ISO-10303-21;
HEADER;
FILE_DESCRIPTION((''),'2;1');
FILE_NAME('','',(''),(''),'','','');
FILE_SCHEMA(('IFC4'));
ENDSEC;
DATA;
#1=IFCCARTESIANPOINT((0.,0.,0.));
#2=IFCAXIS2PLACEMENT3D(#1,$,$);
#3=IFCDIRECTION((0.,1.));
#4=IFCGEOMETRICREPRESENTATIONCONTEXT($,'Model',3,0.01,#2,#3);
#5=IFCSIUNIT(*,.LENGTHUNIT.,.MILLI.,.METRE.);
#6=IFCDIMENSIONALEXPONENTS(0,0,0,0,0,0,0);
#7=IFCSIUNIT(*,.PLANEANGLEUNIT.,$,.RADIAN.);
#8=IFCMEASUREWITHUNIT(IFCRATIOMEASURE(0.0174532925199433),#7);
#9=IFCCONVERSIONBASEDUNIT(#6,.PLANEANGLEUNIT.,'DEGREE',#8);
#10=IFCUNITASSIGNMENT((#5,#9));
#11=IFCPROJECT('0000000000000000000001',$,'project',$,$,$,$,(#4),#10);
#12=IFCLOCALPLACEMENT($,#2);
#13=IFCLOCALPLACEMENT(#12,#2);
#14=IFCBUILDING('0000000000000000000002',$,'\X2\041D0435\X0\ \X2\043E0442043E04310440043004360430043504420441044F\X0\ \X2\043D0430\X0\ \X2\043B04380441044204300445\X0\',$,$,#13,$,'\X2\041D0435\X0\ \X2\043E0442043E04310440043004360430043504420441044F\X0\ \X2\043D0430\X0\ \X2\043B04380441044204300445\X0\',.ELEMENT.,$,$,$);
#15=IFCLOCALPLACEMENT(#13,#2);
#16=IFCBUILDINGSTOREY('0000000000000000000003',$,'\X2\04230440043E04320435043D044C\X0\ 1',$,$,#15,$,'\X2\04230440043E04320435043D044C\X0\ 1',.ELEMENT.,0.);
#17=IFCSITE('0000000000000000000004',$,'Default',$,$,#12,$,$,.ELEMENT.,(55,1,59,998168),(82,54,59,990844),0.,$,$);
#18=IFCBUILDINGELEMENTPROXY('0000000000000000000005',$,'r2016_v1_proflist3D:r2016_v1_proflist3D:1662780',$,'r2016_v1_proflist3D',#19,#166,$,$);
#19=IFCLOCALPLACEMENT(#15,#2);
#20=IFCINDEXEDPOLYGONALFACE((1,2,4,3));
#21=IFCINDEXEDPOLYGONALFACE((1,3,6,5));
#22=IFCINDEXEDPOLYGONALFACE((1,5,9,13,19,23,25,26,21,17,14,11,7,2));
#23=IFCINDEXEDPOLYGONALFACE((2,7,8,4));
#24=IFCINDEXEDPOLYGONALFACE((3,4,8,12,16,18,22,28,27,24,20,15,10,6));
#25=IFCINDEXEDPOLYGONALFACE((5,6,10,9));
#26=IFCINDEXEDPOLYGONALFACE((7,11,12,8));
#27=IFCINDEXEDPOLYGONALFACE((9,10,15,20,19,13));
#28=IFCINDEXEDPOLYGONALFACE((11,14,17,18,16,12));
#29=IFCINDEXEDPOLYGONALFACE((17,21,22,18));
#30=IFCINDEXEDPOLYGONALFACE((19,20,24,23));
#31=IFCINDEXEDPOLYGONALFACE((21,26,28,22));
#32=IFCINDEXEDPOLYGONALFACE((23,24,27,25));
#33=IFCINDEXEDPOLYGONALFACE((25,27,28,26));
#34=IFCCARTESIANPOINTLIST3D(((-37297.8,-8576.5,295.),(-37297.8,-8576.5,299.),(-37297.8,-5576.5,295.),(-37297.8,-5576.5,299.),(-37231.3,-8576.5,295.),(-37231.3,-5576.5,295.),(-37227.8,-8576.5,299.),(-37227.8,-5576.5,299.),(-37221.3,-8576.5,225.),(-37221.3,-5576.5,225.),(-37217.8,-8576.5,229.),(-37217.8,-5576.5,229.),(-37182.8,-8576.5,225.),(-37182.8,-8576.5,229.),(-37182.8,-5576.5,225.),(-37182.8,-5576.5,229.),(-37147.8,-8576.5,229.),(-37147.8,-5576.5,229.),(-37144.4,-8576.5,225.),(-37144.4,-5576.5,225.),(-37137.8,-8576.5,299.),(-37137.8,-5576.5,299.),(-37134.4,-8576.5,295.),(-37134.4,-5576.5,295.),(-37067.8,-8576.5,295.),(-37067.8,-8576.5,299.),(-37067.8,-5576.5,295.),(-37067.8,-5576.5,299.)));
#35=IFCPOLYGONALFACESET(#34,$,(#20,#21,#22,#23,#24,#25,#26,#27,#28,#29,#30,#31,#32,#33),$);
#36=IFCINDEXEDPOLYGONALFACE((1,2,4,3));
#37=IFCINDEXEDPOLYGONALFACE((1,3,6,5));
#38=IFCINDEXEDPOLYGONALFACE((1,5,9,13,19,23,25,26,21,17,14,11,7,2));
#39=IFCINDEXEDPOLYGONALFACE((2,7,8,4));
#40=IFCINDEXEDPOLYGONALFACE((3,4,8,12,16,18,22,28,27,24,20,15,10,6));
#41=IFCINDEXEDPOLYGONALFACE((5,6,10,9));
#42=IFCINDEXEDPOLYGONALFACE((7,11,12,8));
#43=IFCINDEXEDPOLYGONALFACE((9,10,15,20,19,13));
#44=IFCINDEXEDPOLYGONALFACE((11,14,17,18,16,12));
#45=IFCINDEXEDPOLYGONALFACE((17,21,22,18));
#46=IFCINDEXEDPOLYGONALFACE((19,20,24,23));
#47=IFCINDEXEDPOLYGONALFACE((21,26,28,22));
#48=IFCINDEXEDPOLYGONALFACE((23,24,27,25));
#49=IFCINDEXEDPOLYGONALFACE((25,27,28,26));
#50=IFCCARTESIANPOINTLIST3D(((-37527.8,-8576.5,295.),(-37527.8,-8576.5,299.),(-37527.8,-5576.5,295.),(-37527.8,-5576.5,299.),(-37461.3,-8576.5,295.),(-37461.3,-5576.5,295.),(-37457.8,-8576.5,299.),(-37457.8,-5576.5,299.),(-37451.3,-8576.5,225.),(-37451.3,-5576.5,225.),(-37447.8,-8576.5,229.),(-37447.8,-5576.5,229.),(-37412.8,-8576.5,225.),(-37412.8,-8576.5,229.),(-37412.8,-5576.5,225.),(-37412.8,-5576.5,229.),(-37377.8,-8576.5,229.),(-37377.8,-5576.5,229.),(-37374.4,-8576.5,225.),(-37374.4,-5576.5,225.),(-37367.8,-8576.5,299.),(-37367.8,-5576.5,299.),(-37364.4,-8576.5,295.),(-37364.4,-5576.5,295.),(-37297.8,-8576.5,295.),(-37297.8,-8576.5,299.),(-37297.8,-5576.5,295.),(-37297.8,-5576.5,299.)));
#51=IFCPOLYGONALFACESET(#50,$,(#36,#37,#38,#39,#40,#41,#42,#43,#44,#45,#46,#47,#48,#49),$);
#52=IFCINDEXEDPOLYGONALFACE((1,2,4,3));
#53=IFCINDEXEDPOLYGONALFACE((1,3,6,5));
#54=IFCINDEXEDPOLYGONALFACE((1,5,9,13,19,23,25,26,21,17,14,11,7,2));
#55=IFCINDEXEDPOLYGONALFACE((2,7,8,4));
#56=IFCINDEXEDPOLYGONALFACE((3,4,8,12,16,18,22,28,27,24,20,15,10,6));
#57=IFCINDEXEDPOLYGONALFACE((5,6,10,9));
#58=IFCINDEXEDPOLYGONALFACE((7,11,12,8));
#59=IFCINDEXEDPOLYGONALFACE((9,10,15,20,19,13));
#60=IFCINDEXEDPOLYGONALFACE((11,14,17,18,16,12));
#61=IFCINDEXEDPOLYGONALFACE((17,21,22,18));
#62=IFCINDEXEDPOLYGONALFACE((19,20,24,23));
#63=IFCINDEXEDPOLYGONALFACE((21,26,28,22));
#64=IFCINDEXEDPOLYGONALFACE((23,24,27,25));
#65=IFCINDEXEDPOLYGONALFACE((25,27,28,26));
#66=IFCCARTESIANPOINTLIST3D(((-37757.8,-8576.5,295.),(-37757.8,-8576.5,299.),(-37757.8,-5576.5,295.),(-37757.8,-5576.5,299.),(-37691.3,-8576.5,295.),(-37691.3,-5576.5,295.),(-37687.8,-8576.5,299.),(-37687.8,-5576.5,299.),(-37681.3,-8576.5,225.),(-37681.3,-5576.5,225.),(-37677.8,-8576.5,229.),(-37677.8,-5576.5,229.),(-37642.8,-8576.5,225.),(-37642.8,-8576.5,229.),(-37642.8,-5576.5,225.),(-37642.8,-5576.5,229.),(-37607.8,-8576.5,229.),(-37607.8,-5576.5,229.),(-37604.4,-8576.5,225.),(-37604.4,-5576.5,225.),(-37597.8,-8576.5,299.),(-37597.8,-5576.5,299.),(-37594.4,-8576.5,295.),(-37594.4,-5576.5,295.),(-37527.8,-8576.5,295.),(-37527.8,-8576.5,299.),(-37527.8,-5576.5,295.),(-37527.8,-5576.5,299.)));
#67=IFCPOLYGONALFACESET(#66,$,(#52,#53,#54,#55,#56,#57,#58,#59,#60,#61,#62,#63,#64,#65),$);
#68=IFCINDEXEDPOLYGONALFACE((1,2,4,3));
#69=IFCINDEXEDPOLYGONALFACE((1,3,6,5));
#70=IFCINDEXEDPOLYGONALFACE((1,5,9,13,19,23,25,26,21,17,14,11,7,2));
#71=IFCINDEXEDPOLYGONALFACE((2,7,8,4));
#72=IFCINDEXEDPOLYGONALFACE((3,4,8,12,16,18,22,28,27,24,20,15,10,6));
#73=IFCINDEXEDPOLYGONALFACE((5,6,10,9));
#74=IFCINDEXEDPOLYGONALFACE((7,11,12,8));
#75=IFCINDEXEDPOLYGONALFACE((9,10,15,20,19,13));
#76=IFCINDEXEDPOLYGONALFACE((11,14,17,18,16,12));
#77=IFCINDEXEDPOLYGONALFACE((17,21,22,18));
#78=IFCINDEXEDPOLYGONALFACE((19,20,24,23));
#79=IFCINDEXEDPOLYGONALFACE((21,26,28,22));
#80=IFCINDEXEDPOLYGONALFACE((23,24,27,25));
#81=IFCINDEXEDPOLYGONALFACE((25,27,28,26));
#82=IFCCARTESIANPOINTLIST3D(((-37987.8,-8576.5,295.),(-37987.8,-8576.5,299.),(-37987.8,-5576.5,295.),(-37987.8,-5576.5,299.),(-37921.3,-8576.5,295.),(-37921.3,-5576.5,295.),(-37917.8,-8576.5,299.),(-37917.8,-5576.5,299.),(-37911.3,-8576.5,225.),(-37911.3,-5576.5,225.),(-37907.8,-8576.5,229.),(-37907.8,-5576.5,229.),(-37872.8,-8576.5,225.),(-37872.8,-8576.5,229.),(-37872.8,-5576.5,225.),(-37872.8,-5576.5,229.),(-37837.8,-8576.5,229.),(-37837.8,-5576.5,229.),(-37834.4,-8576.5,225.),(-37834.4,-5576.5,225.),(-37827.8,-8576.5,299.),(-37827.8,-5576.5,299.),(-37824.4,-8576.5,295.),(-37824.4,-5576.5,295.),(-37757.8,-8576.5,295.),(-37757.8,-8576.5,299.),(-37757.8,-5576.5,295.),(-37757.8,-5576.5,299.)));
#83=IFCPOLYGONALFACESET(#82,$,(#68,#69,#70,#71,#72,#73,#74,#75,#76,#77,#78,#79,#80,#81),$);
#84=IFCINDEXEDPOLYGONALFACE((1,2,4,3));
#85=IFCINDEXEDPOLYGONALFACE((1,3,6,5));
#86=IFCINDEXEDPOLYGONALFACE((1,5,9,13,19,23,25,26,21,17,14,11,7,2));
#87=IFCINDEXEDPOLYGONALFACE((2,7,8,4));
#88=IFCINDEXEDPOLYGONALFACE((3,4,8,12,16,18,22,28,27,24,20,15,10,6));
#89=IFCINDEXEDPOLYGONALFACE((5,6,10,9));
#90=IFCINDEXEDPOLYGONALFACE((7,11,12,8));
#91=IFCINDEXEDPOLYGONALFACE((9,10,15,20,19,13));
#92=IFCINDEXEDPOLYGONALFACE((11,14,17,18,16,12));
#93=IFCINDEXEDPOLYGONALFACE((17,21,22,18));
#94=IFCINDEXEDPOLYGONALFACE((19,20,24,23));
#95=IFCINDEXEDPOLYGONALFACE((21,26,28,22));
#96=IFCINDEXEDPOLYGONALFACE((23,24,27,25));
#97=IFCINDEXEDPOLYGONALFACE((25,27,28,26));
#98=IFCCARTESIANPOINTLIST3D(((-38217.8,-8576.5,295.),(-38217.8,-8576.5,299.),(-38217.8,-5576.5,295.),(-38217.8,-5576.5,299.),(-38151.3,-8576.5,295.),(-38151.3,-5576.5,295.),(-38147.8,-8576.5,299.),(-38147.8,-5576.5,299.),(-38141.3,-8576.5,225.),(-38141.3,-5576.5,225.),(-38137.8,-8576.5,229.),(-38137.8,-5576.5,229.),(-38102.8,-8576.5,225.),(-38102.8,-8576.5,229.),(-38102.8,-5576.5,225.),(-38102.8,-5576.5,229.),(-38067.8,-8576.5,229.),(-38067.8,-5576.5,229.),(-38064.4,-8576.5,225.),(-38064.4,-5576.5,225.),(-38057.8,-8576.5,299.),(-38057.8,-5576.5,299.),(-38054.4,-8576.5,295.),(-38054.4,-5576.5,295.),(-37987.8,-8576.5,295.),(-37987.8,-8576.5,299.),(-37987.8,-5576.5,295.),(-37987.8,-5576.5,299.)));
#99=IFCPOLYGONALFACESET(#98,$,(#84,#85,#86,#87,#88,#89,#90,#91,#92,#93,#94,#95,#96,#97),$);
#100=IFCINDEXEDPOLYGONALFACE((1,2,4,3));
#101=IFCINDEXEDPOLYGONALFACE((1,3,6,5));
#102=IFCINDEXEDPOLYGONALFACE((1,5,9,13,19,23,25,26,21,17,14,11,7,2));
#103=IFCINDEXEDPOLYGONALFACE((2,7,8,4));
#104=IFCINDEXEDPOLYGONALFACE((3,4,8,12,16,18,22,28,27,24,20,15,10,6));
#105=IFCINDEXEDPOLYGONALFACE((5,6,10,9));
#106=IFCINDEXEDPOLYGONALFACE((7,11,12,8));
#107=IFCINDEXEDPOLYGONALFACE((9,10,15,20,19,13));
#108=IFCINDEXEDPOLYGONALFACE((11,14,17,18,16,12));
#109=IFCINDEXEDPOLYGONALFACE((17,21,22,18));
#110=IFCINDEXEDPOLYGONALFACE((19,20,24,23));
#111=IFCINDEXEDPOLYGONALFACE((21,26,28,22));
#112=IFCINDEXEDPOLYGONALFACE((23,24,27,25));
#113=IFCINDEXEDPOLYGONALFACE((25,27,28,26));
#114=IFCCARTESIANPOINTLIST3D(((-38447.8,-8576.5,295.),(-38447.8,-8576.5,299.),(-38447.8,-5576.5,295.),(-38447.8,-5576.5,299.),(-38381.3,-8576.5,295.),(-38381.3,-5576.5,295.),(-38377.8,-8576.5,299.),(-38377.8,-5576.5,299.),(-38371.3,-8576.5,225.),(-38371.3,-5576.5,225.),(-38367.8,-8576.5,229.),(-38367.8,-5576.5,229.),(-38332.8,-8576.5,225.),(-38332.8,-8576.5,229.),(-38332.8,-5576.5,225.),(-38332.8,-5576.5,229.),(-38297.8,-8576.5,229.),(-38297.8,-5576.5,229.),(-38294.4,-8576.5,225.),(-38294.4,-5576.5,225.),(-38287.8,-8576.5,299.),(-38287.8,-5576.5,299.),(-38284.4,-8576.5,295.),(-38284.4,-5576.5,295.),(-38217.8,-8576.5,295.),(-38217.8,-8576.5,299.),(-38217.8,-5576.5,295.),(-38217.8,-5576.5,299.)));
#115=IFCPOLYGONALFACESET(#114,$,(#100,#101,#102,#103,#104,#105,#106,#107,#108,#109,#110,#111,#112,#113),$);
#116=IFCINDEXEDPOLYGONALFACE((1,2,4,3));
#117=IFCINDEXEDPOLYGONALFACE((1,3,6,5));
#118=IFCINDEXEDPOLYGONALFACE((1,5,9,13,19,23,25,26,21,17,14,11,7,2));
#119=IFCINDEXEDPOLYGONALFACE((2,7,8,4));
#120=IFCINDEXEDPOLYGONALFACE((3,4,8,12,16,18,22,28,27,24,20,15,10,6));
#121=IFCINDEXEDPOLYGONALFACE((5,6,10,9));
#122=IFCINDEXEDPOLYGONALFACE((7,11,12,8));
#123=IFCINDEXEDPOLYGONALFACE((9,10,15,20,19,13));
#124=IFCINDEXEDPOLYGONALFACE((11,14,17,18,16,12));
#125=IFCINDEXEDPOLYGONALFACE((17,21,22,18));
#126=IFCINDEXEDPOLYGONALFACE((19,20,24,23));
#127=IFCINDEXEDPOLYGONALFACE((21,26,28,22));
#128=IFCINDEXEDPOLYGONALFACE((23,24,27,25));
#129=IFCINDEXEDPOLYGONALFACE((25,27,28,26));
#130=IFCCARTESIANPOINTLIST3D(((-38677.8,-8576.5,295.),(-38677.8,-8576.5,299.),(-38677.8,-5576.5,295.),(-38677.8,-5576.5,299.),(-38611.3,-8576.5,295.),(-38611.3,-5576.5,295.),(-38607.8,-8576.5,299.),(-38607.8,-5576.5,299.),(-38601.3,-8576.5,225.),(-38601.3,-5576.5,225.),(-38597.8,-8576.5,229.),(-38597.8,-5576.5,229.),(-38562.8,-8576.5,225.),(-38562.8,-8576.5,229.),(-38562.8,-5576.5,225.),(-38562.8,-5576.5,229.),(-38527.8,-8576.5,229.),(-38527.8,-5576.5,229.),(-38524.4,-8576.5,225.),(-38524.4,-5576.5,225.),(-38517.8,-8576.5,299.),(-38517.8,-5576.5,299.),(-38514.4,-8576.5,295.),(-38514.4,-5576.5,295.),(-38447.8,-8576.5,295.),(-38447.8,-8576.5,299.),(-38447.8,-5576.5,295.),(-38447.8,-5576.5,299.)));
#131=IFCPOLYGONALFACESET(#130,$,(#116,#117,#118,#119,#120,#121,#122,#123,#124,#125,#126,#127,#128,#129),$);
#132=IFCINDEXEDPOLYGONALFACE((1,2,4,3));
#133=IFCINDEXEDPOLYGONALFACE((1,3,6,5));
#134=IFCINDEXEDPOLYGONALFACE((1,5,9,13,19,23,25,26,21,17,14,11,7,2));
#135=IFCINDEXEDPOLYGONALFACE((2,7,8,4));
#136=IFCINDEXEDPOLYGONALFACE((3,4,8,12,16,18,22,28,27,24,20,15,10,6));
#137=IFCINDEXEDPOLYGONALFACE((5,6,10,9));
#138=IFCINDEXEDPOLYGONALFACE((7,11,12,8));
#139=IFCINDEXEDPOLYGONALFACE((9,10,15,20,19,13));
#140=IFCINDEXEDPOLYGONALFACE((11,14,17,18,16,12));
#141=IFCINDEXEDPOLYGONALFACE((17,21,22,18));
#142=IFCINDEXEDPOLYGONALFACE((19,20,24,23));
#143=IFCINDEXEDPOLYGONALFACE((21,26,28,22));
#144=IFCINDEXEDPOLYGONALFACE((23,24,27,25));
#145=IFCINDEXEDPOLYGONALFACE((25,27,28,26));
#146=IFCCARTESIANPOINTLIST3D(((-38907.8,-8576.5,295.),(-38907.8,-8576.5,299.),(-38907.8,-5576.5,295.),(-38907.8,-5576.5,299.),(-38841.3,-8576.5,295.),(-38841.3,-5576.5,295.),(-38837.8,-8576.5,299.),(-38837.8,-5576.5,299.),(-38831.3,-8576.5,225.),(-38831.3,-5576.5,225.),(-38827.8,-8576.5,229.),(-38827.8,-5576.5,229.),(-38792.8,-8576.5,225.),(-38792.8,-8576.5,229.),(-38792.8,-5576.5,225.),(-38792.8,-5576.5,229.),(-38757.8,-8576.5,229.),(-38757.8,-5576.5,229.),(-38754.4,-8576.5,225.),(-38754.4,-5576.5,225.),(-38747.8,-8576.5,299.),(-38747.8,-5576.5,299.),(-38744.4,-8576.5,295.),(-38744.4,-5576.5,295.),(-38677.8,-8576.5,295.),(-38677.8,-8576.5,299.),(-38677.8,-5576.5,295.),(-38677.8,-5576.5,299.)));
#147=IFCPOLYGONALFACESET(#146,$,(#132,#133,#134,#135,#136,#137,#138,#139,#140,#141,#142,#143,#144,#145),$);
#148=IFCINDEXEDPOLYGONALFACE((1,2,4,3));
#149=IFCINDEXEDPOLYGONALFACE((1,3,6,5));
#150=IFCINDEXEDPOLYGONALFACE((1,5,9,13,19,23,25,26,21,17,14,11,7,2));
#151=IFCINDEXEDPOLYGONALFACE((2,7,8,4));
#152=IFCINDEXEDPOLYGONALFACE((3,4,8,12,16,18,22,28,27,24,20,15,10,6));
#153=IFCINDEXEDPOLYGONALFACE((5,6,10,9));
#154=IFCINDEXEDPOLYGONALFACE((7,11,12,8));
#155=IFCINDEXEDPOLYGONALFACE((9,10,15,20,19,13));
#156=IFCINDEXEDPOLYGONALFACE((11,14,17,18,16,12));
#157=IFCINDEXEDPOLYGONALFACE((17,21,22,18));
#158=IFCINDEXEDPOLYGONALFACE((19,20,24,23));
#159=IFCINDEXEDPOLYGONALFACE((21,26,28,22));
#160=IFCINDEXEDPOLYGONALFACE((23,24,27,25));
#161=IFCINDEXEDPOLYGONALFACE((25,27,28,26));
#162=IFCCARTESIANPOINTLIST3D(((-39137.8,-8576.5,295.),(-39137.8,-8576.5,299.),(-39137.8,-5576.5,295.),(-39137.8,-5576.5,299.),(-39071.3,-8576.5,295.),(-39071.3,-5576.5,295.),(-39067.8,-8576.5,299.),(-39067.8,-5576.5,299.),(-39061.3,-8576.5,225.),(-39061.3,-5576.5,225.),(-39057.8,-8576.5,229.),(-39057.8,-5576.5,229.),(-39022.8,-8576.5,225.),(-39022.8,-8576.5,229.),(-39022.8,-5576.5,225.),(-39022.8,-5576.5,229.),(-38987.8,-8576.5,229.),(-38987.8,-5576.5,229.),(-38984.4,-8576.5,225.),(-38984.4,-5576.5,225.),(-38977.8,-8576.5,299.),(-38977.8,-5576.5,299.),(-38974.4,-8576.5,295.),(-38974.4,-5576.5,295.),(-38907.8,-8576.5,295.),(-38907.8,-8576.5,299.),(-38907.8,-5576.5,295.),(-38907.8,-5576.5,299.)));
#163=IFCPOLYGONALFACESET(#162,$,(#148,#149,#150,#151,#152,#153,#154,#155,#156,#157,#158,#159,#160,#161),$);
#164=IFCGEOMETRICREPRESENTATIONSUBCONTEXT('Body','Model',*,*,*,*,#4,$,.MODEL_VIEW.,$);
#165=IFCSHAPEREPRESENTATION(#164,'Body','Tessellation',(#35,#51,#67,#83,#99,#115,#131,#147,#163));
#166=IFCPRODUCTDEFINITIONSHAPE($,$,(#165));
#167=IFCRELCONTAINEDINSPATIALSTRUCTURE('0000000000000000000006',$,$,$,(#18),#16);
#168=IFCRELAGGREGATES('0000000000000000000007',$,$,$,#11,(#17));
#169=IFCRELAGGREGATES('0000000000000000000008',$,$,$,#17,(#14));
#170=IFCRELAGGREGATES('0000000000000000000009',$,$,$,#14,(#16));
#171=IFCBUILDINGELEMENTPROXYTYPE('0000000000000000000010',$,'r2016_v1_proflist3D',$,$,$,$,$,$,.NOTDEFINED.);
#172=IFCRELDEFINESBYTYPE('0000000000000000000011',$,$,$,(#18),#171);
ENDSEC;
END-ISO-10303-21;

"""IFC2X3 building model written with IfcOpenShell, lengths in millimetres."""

from ifc_helpers import new_model, entity, si_unit, converted_unit, direction, frame, origin, place, context, subcontext, project, spatial, polyline, outline, extrude, source, transform, mapped, type_object, type_shapes, element, save


model = new_model("IFC2X3")

# Units and contexts
model_context = context("Model", 3, precision=0.01, world=origin(), true_north=direction((0.0, 1.0)))
body_context = subcontext(model_context, "Body", "Model", "MODEL_VIEW")
ifc_project = project(units=[si_unit("LENGTHUNIT", "METRE", prefix="MILLI"), converted_unit("PLANEANGLEUNIT", "DEGREE", entity("IfcRatioMeasure", 0.0174532925199433), si_unit("PLANEANGLEUNIT", "RADIAN"), dimensions=[0, 0, 0, 0, 0, 0, 0])], contexts=[model_context])

# Site, building, storey
site_placement = place(None, origin())
site = spatial("IfcSite", under=ifc_project, at=site_placement, Name="Default", CompositionType="ELEMENT", RefLatitude=(55, 1, 59, 998168), RefLongitude=(82, 54, 59, 990844), RefElevation=0.0)
building_placement = place(site_placement, origin())
building = spatial("IfcBuilding", under=site, at=building_placement, Name="Не отображается на листах", LongName="Не отображается на листах", CompositionType="ELEMENT")
storey_placement = place(building_placement, frame((0.0, 0.0, 0.0)))
storey = spatial("IfcBuildingStorey", under=building, at=storey_placement, Name="Уровень 1", LongName="Уровень 1", CompositionType="ELEMENT", Elevation=0.0)

# Building element proxy
building_element_proxy_type = type_object("IfcBuildingElementProxyType", Name="r2016_v1_proflist3D", PredefinedType="NOTDEFINED")
shared_shape = source(origin(), body_context, "Body", "SweptSolid", [
    extrude(outline(polyline([(-38.0, -40.0), (-47.9, -109.3), (-44.0, -109.9), (-34.6, -44.0), (36.1, -44.0), (41.6, -5.9), (47.0, 32.1), (-20.9, 51.9), (-11.5, 117.8), (-15.4, 118.4), (-25.3, 49.1), (42.6, 29.3), (37.6, -5.4), (32.7, -40.0), (-38.0, -40.0)])), frame((1955.0, -3000.0, -32.0), z_axis=(0.0, -1.0, 0.0), x_axis=(0.141421, 0.0, -0.989949)), (0.0, 0.0, -1.0), 3000.0),
    extrude(outline(polyline([(-38.0, -40.0), (-47.9, -109.3), (-44.0, -109.9), (-34.6, -44.0), (36.1, -44.0), (41.6, -5.9), (47.0, 32.1), (-20.9, 51.9), (-11.5, 117.8), (-15.4, 118.4), (-25.3, 49.1), (42.6, 29.3), (37.6, -5.4), (32.7, -40.0), (-38.0, -40.0)])), frame((1725.0, -3000.0, -32.0), z_axis=(0.0, -1.0, 0.0), x_axis=(0.141421, 0.0, -0.989949)), (0.0, 0.0, -1.0), 3000.0),
    extrude(outline(polyline([(-38.0, -40.0), (-47.9, -109.3), (-44.0, -109.9), (-34.6, -44.0), (36.1, -44.0), (41.6, -5.9), (47.0, 32.1), (-20.9, 51.9), (-11.5, 117.8), (-15.4, 118.4), (-25.3, 49.1), (42.6, 29.3), (37.6, -5.4), (32.7, -40.0), (-38.0, -40.0)])), frame((1495.0, -3000.0, -32.0), z_axis=(0.0, -1.0, 0.0), x_axis=(0.141421, 0.0, -0.989949)), (0.0, 0.0, -1.0), 3000.0),
    extrude(outline(polyline([(-38.0, -40.0), (-47.9, -109.3), (-44.0, -109.9), (-34.6, -44.0), (36.1, -44.0), (41.6, -5.9), (47.0, 32.1), (-20.9, 51.9), (-11.5, 117.8), (-15.4, 118.4), (-25.3, 49.1), (42.6, 29.3), (37.6, -5.4), (32.7, -40.0), (-38.0, -40.0)])), frame((1265.0, -3000.0, -32.0), z_axis=(0.0, -1.0, 0.0), x_axis=(0.141421, 0.0, -0.989949)), (0.0, 0.0, -1.0), 3000.0),
    extrude(outline(polyline([(-38.0, -40.0), (-47.9, -109.3), (-44.0, -109.9), (-34.6, -44.0), (36.1, -44.0), (41.6, -5.9), (47.0, 32.1), (-20.9, 51.9), (-11.5, 117.8), (-15.4, 118.4), (-25.3, 49.1), (42.6, 29.3), (37.6, -5.4), (32.7, -40.0), (-38.0, -40.0)])), frame((1035.0, -3000.0, -32.0), z_axis=(0.0, -1.0, 0.0), x_axis=(0.141421, 0.0, -0.989949)), (0.0, 0.0, -1.0), 3000.0),
    extrude(outline(polyline([(-38.0, -40.0), (-47.9, -109.3), (-44.0, -109.9), (-34.6, -44.0), (36.1, -44.0), (41.6, -5.9), (47.0, 32.1), (-20.9, 51.9), (-11.5, 117.8), (-15.4, 118.4), (-25.3, 49.1), (42.6, 29.3), (37.6, -5.4), (32.7, -40.0), (-38.0, -40.0)])), frame((805.0, -3000.0, -32.0), z_axis=(0.0, -1.0, 0.0), x_axis=(0.141421, 0.0, -0.989949)), (0.0, 0.0, -1.0), 3000.0),
    extrude(outline(polyline([(-38.0, -40.0), (-47.9, -109.3), (-44.0, -109.9), (-34.6, -44.0), (36.1, -44.0), (41.6, -5.9), (47.0, 32.1), (-20.9, 51.9), (-11.5, 117.8), (-15.4, 118.4), (-25.3, 49.1), (42.6, 29.3), (37.6, -5.4), (32.7, -40.0), (-38.0, -40.0)])), frame((575.0, -3000.0, -32.0), z_axis=(0.0, -1.0, 0.0), x_axis=(0.141421, 0.0, -0.989949)), (0.0, 0.0, -1.0), 3000.0),
    extrude(outline(polyline([(-38.0, -40.0), (-47.9, -109.3), (-44.0, -109.9), (-34.6, -44.0), (36.1, -44.0), (41.6, -5.9), (47.0, 32.1), (-20.9, 51.9), (-11.5, 117.8), (-15.4, 118.4), (-25.3, 49.1), (42.6, 29.3), (37.6, -5.4), (32.7, -40.0), (-38.0, -40.0)])), frame((345.0, -3000.0, -32.0), z_axis=(0.0, -1.0, 0.0), x_axis=(0.141421, 0.0, -0.989949)), (0.0, 0.0, -1.0), 3000.0),
    extrude(outline(polyline([(-38.0, -40.0), (-47.9, -109.3), (-44.0, -109.9), (-34.6, -44.0), (36.1, -44.0), (41.6, -5.9), (47.0, 32.1), (-20.9, 51.9), (-11.5, 117.8), (-15.4, 118.4), (-25.3, 49.1), (42.6, 29.3), (37.6, -5.4), (32.7, -40.0), (-38.0, -40.0)])), frame((115.0, -3000.0, -32.0), z_axis=(0.0, -1.0, 0.0), x_axis=(0.141421, 0.0, -0.989949)), (0.0, 0.0, -1.0), 3000.0),
])
type_shapes(building_element_proxy_type, [shared_shape])
proxy_1_placement = place(storey_placement, frame((-39137.8, -5576.5, 299.0)))
element("IfcBuildingElementProxy", 1, at=proxy_1_placement, inside=storey, type_object=building_element_proxy_type, Name="r2016_v1_proflist3D:r2016_v1_proflist3D:1662780", ObjectType="r2016_v1_proflist3D", context=body_context, shape_type="MappedRepresentation", body=[
    mapped(shared_shape, transform((0.0, 0.0, 0.0), scale=1.0)),
])

save(model, "model.ifc")
